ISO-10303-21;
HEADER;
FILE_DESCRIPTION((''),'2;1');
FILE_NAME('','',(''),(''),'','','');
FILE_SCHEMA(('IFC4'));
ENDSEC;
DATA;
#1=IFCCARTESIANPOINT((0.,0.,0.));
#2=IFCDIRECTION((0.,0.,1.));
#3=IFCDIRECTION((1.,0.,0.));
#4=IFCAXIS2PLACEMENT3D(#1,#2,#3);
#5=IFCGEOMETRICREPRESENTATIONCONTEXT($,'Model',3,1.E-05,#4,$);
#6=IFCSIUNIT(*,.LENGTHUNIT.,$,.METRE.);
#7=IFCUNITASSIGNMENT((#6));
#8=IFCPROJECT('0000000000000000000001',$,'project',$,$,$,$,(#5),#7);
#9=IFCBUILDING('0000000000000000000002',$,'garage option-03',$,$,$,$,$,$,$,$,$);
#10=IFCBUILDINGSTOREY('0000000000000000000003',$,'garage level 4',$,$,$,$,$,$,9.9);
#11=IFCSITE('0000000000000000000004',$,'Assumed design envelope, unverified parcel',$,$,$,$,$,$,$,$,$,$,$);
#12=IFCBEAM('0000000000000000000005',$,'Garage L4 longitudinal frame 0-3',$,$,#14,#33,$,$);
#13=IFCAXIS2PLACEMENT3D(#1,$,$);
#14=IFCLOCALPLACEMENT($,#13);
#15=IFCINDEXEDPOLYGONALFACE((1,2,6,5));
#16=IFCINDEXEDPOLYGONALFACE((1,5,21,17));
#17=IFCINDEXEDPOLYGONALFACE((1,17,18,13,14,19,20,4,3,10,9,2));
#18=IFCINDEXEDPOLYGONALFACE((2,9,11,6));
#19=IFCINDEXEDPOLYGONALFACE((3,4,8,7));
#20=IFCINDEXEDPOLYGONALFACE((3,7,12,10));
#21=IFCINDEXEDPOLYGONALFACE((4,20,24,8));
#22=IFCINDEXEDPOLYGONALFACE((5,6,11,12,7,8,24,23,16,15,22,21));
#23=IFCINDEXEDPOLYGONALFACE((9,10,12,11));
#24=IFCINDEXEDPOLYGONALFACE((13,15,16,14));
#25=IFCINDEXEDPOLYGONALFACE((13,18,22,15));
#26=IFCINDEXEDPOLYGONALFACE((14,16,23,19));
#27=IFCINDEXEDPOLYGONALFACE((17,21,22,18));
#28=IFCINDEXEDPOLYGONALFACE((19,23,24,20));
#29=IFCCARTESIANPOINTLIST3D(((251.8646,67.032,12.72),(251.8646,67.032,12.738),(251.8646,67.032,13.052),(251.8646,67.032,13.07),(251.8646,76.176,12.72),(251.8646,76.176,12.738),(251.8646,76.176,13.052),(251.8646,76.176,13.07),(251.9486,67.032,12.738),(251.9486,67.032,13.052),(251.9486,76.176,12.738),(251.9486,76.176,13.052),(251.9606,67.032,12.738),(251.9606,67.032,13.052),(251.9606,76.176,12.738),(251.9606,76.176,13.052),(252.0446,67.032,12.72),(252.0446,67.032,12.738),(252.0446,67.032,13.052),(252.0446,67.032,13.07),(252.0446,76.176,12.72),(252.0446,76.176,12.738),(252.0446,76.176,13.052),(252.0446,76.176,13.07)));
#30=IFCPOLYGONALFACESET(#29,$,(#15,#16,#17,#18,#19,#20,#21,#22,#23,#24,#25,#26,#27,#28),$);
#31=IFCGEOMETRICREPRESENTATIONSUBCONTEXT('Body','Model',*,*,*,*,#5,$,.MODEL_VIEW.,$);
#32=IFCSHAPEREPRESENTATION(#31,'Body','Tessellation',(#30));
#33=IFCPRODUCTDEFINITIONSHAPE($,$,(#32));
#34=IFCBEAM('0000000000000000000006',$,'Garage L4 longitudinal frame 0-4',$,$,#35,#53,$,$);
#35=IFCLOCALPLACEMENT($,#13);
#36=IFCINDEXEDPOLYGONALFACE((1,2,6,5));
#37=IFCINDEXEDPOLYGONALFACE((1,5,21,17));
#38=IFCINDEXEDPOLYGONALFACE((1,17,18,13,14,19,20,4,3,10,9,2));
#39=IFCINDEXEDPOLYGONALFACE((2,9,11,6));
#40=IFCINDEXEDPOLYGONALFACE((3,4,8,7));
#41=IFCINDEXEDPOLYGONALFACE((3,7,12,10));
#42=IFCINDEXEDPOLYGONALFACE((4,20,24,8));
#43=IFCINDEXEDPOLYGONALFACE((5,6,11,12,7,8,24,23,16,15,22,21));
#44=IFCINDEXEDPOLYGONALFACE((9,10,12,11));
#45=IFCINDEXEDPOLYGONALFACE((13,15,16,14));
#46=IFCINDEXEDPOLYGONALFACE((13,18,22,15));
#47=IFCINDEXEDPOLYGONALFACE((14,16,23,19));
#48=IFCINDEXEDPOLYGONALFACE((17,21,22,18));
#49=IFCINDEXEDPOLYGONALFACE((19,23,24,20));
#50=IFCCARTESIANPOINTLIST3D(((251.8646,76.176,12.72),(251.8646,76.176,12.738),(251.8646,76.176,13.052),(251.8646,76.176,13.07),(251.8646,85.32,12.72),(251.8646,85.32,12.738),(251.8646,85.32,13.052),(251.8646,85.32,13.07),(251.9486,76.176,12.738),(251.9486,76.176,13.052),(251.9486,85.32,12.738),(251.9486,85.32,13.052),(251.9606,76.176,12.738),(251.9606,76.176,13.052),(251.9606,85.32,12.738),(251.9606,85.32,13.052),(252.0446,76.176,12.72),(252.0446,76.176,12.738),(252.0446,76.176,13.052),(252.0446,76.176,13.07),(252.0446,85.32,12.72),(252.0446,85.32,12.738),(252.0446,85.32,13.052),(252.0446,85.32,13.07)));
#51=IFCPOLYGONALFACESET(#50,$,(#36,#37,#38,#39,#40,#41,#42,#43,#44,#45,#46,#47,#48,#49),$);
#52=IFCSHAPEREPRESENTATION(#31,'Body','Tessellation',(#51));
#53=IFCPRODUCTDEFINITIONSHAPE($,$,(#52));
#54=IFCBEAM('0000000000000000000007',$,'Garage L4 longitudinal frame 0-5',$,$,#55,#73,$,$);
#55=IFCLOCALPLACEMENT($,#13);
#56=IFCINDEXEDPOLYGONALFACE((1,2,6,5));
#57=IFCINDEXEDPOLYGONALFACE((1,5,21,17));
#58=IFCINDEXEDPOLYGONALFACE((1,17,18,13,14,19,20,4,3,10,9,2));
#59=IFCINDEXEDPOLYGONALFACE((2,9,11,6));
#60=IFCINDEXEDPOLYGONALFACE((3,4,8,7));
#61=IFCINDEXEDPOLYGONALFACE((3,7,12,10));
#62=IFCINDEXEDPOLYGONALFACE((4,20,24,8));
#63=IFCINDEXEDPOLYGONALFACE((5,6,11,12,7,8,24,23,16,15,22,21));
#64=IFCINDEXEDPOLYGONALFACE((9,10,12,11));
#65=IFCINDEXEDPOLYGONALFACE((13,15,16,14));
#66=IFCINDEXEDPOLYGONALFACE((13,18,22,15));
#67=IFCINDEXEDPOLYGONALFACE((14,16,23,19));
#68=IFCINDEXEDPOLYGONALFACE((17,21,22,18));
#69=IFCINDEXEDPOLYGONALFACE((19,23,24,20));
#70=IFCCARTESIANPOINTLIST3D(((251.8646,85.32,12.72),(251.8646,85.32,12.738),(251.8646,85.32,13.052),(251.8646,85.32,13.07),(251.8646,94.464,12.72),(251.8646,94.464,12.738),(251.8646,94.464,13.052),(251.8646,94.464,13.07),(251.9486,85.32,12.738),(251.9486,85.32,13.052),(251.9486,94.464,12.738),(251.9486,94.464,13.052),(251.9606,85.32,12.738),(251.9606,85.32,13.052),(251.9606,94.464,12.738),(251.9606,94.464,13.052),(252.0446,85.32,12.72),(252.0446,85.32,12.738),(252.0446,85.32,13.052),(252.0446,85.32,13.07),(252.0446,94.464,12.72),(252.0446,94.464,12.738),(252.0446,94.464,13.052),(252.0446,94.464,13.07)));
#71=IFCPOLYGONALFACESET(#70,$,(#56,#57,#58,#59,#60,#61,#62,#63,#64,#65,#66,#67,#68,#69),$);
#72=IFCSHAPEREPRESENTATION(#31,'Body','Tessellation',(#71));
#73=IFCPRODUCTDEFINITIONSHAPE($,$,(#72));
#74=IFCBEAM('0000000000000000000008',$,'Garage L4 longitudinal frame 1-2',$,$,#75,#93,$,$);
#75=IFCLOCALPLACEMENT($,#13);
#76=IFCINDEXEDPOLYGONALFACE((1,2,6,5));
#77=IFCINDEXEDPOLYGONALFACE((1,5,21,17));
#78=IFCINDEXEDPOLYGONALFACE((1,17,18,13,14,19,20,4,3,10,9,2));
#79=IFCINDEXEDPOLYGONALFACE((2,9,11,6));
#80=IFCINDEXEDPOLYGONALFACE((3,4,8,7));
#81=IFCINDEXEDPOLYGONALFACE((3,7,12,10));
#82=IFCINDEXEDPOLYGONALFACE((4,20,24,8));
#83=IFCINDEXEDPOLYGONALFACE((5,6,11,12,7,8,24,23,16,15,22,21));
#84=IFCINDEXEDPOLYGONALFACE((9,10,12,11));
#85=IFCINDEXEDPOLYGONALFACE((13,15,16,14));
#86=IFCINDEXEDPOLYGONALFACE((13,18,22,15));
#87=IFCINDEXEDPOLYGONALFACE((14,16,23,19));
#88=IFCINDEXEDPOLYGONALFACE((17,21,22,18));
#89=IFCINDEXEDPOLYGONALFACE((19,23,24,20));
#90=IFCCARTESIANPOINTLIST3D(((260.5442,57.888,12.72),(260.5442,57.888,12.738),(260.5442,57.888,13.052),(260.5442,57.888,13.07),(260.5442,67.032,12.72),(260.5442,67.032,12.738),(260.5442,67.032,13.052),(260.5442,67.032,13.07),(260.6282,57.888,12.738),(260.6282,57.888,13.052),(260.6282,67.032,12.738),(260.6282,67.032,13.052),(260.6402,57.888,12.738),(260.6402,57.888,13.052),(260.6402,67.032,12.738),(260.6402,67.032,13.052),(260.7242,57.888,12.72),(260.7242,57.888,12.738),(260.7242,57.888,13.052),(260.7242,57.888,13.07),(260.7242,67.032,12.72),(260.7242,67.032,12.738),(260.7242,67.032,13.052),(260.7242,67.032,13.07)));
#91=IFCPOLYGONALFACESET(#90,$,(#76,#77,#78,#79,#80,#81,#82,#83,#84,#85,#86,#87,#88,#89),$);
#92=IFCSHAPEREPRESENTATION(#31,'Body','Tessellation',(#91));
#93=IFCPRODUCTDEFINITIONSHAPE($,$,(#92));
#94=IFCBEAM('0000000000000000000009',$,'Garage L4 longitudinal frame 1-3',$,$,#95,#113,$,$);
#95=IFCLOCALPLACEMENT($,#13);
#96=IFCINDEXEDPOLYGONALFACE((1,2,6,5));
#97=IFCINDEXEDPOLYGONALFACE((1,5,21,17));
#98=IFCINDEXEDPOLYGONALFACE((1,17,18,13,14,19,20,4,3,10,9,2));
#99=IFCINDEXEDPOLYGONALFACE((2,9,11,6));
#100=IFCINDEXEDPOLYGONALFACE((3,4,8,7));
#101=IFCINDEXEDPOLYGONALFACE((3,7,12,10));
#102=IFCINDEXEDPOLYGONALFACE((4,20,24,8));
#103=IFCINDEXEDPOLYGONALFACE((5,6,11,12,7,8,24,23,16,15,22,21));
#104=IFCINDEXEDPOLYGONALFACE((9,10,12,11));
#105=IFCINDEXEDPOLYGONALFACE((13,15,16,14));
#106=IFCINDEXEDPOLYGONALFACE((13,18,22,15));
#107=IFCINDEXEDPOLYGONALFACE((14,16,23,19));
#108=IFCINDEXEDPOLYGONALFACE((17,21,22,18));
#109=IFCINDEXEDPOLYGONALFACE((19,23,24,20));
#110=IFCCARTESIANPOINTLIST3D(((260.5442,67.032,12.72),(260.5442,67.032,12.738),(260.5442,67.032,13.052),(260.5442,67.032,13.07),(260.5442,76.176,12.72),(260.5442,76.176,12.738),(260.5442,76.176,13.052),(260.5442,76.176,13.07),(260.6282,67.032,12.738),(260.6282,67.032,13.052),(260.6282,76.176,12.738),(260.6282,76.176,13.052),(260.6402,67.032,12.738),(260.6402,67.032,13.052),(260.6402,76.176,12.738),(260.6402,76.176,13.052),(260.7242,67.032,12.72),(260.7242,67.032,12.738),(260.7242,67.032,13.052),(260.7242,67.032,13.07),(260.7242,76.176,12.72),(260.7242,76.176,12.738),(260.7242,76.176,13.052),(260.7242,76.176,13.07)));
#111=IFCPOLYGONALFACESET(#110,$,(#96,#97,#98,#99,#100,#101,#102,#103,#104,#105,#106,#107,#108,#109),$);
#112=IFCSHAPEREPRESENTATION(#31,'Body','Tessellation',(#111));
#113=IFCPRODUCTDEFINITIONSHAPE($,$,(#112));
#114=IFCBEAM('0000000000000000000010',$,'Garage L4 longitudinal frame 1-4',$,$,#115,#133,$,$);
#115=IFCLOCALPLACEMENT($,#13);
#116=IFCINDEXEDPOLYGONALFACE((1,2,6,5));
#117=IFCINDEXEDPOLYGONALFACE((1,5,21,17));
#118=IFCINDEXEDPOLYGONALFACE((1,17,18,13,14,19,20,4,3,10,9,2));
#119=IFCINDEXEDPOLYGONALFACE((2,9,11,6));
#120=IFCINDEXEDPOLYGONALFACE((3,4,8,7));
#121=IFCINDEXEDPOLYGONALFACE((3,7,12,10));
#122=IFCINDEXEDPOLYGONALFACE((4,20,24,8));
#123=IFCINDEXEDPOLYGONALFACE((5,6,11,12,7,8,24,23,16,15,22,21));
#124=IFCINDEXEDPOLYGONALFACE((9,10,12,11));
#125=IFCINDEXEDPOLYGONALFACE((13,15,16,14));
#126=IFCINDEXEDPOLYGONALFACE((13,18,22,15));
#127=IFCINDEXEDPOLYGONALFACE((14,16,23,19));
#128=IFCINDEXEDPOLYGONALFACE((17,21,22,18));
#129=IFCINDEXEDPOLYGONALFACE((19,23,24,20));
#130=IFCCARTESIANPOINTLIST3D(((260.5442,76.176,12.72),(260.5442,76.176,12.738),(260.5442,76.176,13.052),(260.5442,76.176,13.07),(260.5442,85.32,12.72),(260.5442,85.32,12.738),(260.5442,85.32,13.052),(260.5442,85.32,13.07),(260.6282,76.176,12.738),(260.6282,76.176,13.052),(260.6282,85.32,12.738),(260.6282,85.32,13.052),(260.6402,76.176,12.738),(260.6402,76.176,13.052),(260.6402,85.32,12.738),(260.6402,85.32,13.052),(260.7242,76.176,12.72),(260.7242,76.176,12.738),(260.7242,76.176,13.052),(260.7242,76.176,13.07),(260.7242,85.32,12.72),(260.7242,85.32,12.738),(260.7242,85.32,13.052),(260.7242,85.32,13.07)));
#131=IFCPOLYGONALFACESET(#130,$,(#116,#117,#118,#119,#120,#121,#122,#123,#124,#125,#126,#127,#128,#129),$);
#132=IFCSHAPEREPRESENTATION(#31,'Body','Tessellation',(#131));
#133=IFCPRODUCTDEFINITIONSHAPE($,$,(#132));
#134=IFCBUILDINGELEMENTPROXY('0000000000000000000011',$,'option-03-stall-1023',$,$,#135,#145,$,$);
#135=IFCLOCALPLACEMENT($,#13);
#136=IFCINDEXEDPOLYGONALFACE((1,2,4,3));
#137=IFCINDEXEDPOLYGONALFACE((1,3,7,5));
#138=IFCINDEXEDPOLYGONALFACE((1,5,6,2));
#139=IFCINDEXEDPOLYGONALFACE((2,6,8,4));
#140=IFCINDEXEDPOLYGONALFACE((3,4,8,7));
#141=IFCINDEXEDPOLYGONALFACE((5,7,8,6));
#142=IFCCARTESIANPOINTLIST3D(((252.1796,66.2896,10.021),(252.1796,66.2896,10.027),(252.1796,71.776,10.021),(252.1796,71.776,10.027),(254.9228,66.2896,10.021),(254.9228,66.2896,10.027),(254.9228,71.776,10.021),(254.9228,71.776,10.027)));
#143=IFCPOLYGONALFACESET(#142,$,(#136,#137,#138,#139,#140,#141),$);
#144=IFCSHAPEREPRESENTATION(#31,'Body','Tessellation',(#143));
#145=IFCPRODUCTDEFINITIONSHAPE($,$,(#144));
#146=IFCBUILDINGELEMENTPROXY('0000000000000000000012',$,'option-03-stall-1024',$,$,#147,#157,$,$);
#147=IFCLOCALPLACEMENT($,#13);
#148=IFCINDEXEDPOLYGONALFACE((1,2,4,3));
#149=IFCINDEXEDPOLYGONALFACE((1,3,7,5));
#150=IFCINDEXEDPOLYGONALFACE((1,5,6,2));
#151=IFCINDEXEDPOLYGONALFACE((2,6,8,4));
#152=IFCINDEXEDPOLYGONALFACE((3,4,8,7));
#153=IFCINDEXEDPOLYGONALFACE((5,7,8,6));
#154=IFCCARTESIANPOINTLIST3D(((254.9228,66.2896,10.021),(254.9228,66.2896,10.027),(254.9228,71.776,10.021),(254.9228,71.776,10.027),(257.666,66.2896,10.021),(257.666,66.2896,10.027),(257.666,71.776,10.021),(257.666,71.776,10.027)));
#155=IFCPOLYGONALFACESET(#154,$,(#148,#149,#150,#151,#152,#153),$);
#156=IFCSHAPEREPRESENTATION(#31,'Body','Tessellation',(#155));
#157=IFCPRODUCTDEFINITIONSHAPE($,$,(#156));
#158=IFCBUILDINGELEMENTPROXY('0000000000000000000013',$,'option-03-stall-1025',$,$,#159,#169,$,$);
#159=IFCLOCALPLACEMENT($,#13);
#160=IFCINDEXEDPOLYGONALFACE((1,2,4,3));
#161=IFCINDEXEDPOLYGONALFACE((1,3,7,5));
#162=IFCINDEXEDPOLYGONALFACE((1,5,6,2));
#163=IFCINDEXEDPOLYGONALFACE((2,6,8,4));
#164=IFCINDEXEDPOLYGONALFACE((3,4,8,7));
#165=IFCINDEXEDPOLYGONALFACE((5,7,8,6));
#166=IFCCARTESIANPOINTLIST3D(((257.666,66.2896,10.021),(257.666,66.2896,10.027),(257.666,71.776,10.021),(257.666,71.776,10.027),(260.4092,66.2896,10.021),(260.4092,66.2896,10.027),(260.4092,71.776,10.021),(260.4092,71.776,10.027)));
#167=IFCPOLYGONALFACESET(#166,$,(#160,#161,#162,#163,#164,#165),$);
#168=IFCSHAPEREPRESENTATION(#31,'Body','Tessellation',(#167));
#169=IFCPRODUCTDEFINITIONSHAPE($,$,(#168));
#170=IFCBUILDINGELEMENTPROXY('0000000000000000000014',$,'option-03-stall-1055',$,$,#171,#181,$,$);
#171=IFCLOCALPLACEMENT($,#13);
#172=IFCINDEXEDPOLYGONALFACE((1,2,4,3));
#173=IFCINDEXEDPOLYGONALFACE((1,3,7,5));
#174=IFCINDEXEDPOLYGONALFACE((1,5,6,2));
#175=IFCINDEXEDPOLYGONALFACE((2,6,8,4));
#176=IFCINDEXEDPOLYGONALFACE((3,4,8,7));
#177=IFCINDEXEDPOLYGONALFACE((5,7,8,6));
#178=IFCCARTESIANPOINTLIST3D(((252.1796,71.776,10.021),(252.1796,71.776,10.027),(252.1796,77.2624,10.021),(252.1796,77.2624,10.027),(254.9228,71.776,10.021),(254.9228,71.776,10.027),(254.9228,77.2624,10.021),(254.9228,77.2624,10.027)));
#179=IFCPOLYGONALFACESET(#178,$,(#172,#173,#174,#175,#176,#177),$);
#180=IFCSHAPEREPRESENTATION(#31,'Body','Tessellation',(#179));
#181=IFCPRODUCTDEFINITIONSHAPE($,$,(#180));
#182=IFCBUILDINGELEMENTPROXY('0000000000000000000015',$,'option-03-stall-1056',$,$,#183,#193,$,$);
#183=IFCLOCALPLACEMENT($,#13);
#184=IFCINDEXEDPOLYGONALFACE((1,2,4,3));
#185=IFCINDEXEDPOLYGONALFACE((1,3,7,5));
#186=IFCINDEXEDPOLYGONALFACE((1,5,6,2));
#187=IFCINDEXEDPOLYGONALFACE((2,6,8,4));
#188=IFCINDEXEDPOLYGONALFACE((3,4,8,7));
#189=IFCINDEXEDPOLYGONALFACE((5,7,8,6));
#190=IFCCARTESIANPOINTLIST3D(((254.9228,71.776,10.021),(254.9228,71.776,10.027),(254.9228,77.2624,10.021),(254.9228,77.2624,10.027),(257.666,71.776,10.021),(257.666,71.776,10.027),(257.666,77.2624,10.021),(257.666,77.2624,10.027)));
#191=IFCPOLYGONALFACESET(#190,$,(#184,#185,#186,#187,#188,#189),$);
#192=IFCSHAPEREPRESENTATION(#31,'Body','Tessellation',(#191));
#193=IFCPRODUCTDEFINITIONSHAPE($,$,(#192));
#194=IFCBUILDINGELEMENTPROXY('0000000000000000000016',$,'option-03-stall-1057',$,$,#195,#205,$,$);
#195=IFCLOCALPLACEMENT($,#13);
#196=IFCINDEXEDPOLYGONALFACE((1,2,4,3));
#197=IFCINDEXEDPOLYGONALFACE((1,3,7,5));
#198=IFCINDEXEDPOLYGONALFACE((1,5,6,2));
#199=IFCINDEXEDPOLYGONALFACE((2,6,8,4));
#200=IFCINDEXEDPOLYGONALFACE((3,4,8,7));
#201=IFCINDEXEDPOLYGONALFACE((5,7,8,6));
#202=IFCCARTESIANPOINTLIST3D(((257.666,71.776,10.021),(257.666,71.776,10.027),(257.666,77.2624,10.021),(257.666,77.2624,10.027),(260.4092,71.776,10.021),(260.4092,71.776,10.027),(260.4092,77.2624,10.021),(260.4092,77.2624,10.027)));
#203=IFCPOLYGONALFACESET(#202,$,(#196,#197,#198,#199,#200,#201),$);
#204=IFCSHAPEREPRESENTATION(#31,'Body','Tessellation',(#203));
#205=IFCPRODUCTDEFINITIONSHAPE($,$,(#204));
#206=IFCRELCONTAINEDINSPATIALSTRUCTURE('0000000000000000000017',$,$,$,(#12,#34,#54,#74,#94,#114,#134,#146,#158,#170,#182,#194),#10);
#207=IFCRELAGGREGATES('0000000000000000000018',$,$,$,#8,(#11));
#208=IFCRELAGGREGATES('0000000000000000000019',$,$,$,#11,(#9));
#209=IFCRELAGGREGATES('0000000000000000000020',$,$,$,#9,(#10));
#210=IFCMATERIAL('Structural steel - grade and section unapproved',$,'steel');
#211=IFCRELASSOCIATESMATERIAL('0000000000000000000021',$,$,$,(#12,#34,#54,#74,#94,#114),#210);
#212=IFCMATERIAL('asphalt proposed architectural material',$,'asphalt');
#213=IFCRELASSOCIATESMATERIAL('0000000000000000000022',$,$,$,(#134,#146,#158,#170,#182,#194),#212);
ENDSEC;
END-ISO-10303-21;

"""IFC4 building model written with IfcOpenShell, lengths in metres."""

from ifc_helpers import new_model, si_unit, frame, origin_with_axes, place, context, subcontext, project, spatial, rectangle, i_section, extrude, material, element, save


model = new_model("IFC4")

# Units and contexts
model_context = context("Model", 3, precision=1e-05, world=origin_with_axes())
body_context = subcontext(model_context, "Body", "Model", "MODEL_VIEW")
ifc_project = project(units=[si_unit("LENGTHUNIT", "METRE")], contexts=[model_context])

# Site, building, storey
site = spatial("IfcSite", under=ifc_project, Name="Assumed design envelope, unverified parcel")
building = spatial("IfcBuilding", under=site, Name="garage option-03")
storey = spatial("IfcBuildingStorey", under=building, Name="garage level 4", Elevation=9.9)

# Beams
ifc_material_1 = material(Name="Structural steel - grade and section unapproved", Category="steel")
beam_1_placement = place(None, frame((251.9546, 67.032, 12.895), z_axis=(0.0, 1.0, 0.0), x_axis=(-1.0, 0.0, 0.0)))
element("IfcBeam", 1, at=beam_1_placement, inside=storey, material=ifc_material_1, Name="Garage L4 longitudinal frame 0-3", context=body_context, shape_type="SweptSolid", body=[
    extrude(i_section(OverallWidth=0.18, OverallDepth=0.35, WebThickness=0.012, FlangeThickness=0.018, FilletRadius=0.0), origin_with_axes(), (0.0, 0.0, 1.0), 9.144),
])
for number, where, z_axis, x_axis, name in (
    (2, (251.9546, 76.176, 12.895), (0.0, 1.0, 0.0), (-1.0, 0.0, 0.0), "Garage L4 longitudinal frame 0-4"),
    (3, (251.9546, 85.32, 12.895), (0.0, 1.0, 0.0), (-1.0, 0.0, 0.0), "Garage L4 longitudinal frame 0-5"),
    (4, (260.6342, 57.888, 12.895), (0.0, 1.0, 0.0), (-1.0, 0.0, 0.0), "Garage L4 longitudinal frame 1-2"),
):
    element("IfcBeam", number, at=place(None, frame(where, z_axis=z_axis, x_axis=x_axis)), inside=storey, material=ifc_material_1, Name=name, context=body_context, shape_type="SweptSolid", body=[
        extrude(i_section(OverallWidth=0.18, OverallDepth=0.35, WebThickness=0.012, FlangeThickness=0.018, FilletRadius=0.0), origin_with_axes(), (0.0, 0.0, 1.0), 9.144),
    ])
beam_2_placement = place(None, frame((260.6342, 67.032, 12.895), z_axis=(0.0, 1.0, 0.0), x_axis=(-1.0, 0.0, 0.0)))
element("IfcBeam", 5, at=beam_2_placement, inside=storey, material=ifc_material_1, Name="Garage L4 longitudinal frame 1-3", context=body_context, shape_type="SweptSolid", body=[
    extrude(i_section(OverallWidth=0.18, OverallDepth=0.35, WebThickness=0.012, FlangeThickness=0.018, FilletRadius=0.0), origin_with_axes(), (0.0, 0.0, 1.0), 9.144),
])
beam_3_placement = place(None, frame((260.6342, 76.176, 12.895), z_axis=(0.0, 1.0, 0.0), x_axis=(-1.0, 0.0, 0.0)))
element("IfcBeam", 6, at=beam_3_placement, inside=storey, material=ifc_material_1, Name="Garage L4 longitudinal frame 1-4", context=body_context, shape_type="SweptSolid", body=[
    extrude(i_section(OverallWidth=0.18, OverallDepth=0.35, WebThickness=0.012, FlangeThickness=0.018, FilletRadius=0.0), origin_with_axes(), (0.0, 0.0, 1.0), 9.144),
])

# Building element proxies
ifc_material_2 = material(Name="asphalt proposed architectural material", Category="asphalt")
for number, where, z_axis, x_axis, name in (
    (7, (253.5512, 69.0328, 10.021), (0.0, 0.0, 1.0), (1.0, 0.0, 0.0), "option-03-stall-1023"),
    (8, (256.2944, 69.0328, 10.021), (0.0, 0.0, 1.0), (1.0, 0.0, 0.0), "option-03-stall-1024"),
    (9, (259.0376, 69.0328, 10.021), (0.0, 0.0, 1.0), (1.0, 0.0, 0.0), "option-03-stall-1025"),
    (10, (253.5512, 74.5192, 10.021), (0.0, 0.0, 1.0), (1.0, 0.0, 0.0), "option-03-stall-1055"),
    (11, (256.2944, 74.5192, 10.021), (0.0, 0.0, 1.0), (1.0, 0.0, 0.0), "option-03-stall-1056"),
    (12, (259.0376, 74.5192, 10.021), (0.0, 0.0, 1.0), (1.0, 0.0, 0.0), "option-03-stall-1057"),
):
    element("IfcBuildingElementProxy", number, at=place(None, frame(where, z_axis=z_axis, x_axis=x_axis)), inside=storey, material=ifc_material_2, Name=name, context=body_context, shape_type="SweptSolid", body=[
        extrude(rectangle(XDim=2.7432, YDim=5.4864), origin_with_axes(), (0.0, 0.0, 1.0), 0.006),
    ])

save(model, "model.ifc")
